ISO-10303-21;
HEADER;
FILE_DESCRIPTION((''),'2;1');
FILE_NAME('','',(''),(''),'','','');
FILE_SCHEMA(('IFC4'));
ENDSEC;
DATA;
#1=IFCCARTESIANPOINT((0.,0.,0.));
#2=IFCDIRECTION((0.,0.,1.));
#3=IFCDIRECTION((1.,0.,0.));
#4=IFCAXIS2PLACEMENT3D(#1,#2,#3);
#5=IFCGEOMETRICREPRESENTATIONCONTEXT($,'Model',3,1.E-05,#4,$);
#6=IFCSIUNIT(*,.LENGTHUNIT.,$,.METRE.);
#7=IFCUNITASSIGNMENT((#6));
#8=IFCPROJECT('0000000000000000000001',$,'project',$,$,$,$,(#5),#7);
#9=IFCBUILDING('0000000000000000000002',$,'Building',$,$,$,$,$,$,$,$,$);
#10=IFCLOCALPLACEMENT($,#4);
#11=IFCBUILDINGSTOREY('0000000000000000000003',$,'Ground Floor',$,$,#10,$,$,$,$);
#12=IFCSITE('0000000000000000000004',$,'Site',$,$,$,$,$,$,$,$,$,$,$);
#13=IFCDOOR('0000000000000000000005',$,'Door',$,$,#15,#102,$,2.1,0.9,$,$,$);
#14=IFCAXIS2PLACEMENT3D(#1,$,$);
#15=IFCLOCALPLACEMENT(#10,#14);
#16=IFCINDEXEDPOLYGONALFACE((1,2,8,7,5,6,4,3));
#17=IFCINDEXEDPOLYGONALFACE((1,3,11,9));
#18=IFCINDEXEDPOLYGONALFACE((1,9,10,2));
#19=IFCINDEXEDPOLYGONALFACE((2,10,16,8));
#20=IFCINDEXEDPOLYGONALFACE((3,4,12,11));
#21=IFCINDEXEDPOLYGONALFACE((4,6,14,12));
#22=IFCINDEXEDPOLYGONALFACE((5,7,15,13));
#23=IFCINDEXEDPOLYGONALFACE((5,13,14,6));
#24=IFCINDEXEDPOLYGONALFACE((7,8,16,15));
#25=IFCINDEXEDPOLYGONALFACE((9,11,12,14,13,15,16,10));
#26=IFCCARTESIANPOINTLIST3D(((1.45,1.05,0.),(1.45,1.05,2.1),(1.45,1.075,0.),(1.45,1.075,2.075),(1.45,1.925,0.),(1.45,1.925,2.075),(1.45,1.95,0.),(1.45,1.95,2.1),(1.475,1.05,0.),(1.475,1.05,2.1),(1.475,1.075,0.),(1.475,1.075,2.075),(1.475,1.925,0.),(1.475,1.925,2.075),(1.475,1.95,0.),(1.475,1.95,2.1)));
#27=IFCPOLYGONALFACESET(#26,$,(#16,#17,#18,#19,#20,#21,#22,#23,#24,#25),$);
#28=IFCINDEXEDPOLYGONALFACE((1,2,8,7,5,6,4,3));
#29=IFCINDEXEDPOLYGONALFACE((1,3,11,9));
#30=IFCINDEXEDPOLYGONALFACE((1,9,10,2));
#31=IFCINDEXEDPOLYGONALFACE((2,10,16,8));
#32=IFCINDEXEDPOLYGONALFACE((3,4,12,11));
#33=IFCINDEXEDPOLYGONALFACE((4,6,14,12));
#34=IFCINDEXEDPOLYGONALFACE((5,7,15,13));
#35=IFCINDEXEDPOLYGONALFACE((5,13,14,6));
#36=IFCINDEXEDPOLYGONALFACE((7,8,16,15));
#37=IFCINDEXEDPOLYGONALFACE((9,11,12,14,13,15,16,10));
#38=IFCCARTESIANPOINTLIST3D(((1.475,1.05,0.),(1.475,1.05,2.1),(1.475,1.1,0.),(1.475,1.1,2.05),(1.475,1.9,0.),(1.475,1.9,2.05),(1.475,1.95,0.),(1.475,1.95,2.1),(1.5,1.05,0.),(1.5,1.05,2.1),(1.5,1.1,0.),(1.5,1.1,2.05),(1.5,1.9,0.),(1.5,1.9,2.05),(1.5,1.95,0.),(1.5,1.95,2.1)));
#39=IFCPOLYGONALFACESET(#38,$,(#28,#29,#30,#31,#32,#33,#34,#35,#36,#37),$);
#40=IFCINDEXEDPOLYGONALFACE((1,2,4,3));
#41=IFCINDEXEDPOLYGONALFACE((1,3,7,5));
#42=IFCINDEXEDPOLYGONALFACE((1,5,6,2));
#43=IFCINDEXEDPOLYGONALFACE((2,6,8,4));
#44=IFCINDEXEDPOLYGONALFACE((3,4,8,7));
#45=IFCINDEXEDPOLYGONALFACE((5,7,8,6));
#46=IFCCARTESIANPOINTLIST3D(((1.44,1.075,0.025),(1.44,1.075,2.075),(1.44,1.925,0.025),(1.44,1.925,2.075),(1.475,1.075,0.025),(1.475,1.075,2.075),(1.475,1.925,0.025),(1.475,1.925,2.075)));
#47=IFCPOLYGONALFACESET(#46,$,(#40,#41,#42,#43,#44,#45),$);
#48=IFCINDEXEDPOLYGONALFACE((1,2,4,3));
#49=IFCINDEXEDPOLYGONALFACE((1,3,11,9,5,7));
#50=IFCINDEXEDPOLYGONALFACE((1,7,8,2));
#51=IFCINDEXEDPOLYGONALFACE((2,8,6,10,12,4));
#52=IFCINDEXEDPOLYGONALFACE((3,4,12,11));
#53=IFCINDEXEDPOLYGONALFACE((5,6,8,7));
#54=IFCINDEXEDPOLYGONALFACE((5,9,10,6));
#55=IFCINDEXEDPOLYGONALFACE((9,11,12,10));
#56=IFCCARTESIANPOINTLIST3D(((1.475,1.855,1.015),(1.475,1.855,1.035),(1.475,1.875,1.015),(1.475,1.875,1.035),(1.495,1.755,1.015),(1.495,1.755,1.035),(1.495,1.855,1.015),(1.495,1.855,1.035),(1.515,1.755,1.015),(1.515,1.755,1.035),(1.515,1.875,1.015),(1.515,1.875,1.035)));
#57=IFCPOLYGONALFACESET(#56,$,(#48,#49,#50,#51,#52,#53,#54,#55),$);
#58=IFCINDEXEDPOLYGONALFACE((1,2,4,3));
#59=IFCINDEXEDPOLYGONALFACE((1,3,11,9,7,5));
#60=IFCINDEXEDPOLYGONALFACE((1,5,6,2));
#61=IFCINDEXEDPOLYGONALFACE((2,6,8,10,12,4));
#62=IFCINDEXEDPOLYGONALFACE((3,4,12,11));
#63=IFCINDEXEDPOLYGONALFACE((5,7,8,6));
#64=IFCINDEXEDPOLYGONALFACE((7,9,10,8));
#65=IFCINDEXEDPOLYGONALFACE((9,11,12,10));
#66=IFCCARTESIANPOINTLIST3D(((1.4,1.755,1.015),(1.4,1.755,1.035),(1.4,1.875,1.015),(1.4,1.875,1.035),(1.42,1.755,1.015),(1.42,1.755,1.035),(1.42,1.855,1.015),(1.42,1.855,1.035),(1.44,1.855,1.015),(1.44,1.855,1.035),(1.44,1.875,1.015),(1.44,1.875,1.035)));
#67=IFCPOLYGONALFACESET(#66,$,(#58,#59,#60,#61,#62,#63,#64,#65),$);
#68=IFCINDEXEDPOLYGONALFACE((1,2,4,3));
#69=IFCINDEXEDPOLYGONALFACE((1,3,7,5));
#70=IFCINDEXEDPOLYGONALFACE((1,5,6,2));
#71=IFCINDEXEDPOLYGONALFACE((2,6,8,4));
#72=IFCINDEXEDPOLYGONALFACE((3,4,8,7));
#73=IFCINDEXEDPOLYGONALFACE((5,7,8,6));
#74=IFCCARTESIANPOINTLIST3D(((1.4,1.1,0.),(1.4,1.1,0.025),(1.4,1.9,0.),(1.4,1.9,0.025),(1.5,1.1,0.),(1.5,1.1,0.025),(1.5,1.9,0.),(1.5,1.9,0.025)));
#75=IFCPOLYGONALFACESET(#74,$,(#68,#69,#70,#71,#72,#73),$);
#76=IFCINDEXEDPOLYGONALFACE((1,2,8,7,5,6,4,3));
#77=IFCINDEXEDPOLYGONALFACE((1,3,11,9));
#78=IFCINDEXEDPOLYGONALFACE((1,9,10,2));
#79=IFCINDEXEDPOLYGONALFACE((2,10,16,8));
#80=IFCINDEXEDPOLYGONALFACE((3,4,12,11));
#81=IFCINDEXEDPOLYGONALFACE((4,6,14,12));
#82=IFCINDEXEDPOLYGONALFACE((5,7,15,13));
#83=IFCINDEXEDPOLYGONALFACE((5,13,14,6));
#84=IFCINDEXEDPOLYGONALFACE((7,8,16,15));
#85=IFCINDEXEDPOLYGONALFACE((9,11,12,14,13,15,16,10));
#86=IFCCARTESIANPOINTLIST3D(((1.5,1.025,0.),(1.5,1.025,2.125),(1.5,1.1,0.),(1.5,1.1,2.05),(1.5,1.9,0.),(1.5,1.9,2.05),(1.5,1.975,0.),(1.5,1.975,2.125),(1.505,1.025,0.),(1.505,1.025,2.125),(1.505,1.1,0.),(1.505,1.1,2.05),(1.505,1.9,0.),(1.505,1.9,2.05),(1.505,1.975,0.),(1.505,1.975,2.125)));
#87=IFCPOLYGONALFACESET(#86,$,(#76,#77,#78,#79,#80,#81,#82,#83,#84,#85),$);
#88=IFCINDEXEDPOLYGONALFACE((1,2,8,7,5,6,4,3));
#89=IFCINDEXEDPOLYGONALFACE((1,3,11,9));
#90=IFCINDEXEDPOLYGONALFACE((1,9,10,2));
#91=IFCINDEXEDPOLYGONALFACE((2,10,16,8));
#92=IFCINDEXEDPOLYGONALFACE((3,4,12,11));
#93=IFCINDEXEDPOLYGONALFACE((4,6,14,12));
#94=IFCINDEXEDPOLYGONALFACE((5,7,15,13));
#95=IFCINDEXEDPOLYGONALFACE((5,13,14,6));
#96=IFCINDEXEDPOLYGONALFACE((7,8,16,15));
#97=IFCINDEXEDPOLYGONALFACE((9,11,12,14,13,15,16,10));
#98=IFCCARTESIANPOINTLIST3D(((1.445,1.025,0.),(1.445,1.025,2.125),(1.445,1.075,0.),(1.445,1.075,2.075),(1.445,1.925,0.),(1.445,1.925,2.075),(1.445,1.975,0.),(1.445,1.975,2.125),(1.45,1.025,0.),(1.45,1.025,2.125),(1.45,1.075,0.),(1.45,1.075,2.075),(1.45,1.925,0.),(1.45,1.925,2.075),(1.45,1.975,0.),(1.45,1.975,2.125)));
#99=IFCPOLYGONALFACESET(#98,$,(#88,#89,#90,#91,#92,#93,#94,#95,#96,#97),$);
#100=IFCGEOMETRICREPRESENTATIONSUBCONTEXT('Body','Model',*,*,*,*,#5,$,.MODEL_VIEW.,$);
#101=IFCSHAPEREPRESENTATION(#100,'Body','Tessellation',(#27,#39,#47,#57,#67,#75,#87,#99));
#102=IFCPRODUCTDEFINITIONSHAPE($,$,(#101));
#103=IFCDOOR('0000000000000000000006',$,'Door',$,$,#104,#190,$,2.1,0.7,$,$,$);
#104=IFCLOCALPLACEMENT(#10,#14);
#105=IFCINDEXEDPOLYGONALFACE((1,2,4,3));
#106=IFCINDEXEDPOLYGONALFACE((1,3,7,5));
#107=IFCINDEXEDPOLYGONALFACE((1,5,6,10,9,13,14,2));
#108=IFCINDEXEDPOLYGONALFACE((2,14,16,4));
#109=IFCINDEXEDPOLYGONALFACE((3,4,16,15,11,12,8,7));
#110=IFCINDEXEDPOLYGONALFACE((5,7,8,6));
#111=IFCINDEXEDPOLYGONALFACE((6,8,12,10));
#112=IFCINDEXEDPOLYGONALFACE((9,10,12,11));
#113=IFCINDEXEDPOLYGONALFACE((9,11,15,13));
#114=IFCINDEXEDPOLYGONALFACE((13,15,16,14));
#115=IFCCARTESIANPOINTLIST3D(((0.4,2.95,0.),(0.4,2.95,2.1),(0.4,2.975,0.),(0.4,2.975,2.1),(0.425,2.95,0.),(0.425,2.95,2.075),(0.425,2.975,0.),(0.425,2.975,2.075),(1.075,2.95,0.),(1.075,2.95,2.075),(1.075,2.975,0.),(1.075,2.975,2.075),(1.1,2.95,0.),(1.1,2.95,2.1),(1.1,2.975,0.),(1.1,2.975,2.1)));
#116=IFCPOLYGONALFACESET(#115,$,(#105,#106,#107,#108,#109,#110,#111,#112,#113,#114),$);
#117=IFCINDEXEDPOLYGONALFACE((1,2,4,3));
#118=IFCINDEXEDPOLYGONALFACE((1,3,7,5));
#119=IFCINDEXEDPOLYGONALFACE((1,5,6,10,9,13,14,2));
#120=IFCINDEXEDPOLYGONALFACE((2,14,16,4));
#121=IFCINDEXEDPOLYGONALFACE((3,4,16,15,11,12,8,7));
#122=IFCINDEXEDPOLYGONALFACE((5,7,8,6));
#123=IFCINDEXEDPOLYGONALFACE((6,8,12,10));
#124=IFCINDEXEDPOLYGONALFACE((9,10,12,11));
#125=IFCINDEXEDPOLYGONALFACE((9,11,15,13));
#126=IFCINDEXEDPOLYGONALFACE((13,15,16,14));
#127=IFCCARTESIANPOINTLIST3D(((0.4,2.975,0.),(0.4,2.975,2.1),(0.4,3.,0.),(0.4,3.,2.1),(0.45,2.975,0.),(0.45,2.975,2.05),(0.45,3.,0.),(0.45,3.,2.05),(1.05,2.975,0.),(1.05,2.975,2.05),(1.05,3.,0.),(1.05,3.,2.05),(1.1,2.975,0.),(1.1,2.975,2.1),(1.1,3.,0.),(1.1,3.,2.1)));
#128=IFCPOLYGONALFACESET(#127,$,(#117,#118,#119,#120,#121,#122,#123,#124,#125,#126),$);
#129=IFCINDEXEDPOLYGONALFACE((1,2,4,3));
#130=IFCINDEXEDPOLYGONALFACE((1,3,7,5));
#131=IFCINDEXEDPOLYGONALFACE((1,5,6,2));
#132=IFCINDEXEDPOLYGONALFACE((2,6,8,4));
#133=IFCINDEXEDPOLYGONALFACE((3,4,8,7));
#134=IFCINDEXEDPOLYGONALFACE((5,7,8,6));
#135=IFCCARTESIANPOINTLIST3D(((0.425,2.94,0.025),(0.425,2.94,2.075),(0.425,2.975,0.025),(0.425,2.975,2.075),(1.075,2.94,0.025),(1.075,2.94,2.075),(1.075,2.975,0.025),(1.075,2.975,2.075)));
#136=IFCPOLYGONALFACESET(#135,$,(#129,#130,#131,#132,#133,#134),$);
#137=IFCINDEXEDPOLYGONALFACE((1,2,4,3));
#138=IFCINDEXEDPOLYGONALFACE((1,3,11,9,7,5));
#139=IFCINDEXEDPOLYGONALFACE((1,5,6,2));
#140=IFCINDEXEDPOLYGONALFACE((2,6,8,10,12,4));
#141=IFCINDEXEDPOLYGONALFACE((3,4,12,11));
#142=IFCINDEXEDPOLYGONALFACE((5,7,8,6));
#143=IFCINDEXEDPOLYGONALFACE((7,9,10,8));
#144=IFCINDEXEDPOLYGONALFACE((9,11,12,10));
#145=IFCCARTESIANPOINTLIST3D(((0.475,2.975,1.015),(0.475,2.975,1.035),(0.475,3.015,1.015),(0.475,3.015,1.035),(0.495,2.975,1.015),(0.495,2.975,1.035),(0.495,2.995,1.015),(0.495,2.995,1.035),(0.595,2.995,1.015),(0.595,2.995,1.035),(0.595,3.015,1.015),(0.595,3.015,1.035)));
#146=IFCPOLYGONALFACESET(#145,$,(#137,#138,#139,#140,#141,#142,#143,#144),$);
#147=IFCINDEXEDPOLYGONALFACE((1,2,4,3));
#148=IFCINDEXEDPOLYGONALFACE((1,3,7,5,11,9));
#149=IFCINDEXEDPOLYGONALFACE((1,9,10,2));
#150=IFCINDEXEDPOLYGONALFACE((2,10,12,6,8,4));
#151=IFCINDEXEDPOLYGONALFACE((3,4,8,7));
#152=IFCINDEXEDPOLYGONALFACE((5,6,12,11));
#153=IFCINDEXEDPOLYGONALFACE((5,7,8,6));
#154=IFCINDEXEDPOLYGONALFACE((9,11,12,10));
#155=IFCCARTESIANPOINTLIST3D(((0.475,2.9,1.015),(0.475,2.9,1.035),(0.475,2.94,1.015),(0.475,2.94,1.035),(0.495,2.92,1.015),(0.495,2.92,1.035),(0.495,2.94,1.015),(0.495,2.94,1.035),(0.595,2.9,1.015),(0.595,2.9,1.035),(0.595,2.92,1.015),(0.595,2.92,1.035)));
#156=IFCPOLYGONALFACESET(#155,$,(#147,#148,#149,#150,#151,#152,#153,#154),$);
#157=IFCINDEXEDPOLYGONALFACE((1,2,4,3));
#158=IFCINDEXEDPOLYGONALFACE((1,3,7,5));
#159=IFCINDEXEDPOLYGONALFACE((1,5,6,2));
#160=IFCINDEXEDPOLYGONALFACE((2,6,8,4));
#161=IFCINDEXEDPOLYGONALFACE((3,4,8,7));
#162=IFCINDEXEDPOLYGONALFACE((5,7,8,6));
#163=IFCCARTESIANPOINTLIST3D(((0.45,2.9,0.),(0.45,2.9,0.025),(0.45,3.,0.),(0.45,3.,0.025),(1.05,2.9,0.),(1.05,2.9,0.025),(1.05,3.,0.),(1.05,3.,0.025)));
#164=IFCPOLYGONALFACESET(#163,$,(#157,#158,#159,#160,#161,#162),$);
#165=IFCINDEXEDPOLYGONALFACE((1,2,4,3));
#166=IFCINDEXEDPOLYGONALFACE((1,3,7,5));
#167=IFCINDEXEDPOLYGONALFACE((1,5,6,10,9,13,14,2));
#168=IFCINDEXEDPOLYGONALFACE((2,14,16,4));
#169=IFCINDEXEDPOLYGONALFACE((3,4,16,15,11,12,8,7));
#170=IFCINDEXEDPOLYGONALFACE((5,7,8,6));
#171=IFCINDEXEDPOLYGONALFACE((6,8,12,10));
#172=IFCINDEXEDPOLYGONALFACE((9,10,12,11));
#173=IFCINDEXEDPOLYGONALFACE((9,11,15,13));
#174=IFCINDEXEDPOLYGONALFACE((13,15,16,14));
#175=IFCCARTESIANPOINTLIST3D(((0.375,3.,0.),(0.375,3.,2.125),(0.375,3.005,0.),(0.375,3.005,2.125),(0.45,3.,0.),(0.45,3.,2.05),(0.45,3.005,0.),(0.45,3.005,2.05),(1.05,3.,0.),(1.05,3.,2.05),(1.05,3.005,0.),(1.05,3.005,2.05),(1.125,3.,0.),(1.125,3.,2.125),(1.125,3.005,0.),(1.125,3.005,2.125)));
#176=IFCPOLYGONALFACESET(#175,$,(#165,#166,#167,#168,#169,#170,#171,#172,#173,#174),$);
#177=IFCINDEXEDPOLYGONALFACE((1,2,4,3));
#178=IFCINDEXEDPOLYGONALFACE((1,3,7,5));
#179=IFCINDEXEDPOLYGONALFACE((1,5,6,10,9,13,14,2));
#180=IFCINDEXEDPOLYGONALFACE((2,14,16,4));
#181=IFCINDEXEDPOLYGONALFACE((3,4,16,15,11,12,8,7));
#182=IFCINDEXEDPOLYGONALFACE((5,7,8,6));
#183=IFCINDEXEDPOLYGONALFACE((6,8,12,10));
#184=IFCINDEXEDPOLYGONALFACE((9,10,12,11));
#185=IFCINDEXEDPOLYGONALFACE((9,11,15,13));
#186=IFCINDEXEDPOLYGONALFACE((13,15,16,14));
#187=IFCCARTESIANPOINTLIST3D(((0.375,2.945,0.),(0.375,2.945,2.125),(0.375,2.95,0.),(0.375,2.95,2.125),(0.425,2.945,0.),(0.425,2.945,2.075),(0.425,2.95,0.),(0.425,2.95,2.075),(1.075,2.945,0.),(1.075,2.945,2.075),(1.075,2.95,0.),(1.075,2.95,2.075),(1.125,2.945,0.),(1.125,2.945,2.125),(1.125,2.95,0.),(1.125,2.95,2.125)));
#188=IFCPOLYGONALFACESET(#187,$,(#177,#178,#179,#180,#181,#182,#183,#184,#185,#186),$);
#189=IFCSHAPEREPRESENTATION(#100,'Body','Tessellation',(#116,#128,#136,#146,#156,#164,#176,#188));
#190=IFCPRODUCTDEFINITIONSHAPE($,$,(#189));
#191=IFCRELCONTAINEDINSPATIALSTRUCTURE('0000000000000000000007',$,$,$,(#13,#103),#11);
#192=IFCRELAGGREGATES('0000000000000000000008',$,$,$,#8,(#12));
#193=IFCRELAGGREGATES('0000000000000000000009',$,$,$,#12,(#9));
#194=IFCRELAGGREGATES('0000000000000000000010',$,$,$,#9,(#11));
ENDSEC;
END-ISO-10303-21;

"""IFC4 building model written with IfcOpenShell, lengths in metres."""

from ifc_helpers import new_model, si_unit, frame, origin_with_axes, place, context, subcontext, project, spatial, line, indexed_curve, outline, extrude, element, save


model = new_model("IFC4")

# Units and contexts
model_context = context("Model", 3, precision=1e-05, world=origin_with_axes())
body_context = subcontext(model_context, "Body", "Model", "MODEL_VIEW")
ifc_project = project(units=[si_unit("LENGTHUNIT", "METRE")], contexts=[model_context])

# Site, building, storey
site = spatial("IfcSite", under=ifc_project, Name="Site")
building = spatial("IfcBuilding", under=site, Name="Building")
storey_placement = place(None, origin_with_axes())
storey = spatial("IfcBuildingStorey", under=building, at=storey_placement, Name="Ground Floor")

# Doors
door_1_placement = place(storey_placement, frame((1.5, 1.05, 0.0), z_axis=(0.0, 0.0, 1.0), x_axis=(0.0, 1.0, 0.0)))
element("IfcDoor", 1, at=door_1_placement, inside=storey, Name="Door", OverallHeight=2.1, OverallWidth=0.9, context=body_context, shape_type="SweptSolid", body=[
    extrude(outline(indexed_curve([(0.0, 0.0), (0.0, 2.1), (0.9, 2.1), (0.9, 0.0), (0.875, 0.0), (0.875, 2.075), (0.025, 2.075), (0.025, 0.0)], segments=[line(1, 2, 3, 4, 5, 6, 7, 8, 1)])), frame((0.0, 0.025, 0.0), z_axis=(0.0, -1.0, 0.0), x_axis=(1.0, 0.0, 0.0)), (0.0, 0.0, -1.0), 0.025),
    extrude(outline(indexed_curve([(0.0, 0.0), (0.0, 2.1), (0.9, 2.1), (0.9, 0.0), (0.85, 0.0), (0.85, 2.05), (0.05, 2.05), (0.05, 0.0)], segments=[line(1, 2, 3, 4, 5, 6, 7, 8, 1)])), frame((0.0, 0.0, 0.0), z_axis=(0.0, -1.0, 0.0), x_axis=(1.0, 0.0, 0.0)), (0.0, 0.0, -1.0), 0.025),
    extrude(outline(indexed_curve([(0.0, 0.0), (0.85, 0.0), (0.85, 0.035), (0.0, 0.035)], segments=[line(1, 2, 3, 4, 1)])), frame((0.025, 0.025, 0.025), z_axis=(0.0, 0.0, 1.0), x_axis=(1.0, 0.0, 0.0)), (0.0, 0.0, 1.0), 2.05),
    extrude(outline(indexed_curve([(0.0, 0.0), (0.0, -0.04), (-0.12, -0.04), (-0.12, -0.02), (-0.02, -0.02), (-0.02, 0.0)], segments=[line(1, 2, 3, 4, 5, 6, 1)])), frame((0.825, 0.025, 1.015), z_axis=(0.0, 0.0, 1.0), x_axis=(1.0, 0.0, 0.0)), (0.0, 0.0, 1.0), 0.02),
    extrude(outline(indexed_curve([(0.0, 0.0), (0.0, 0.04), (-0.12, 0.04), (-0.12, 0.02), (-0.02, 0.02), (-0.02, 0.0)], segments=[line(1, 2, 3, 4, 5, 6, 1)])), frame((0.825, 0.06, 1.015), z_axis=(0.0, 0.0, 1.0), x_axis=(1.0, 0.0, 0.0)), (0.0, 0.0, 1.0), 0.02),
    extrude(outline(indexed_curve([(0.0, 0.0), (0.8, 0.0), (0.8, 0.1), (0.0, 0.1)], segments=[line(1, 2, 3, 4, 1)])), frame((0.05, 0.0, 0.0), z_axis=(0.0, 0.0, 1.0), x_axis=(1.0, 0.0, 0.0)), (0.0, 0.0, 1.0), 0.025),
    extrude(outline(indexed_curve([(0.0, 0.0), (0.0, 2.125), (0.95, 2.125), (0.95, 0.0), (0.875, 0.0), (0.875, 2.05), (0.075, 2.05), (0.075, 0.0)], segments=[line(1, 2, 3, 4, 5, 6, 7, 8, 1)])), frame((-0.025, -0.005, 0.0), z_axis=(0.0, -1.0, 0.0), x_axis=(1.0, 0.0, 0.0)), (0.0, 0.0, -1.0), 0.005),
    extrude(outline(indexed_curve([(0.0, 0.0), (0.0, 2.125), (0.95, 2.125), (0.95, 0.0), (0.9, 0.0), (0.9, 2.075), (0.05, 2.075), (0.05, 0.0)], segments=[line(1, 2, 3, 4, 5, 6, 7, 8, 1)])), frame((-0.025, 0.05, 0.0), z_axis=(0.0, -1.0, 0.0), x_axis=(1.0, 0.0, 0.0)), (0.0, 0.0, -1.0), 0.005),
])
door_2_placement = place(storey_placement, frame((1.1, 3.0, 0.0), z_axis=(0.0, 0.0, 1.0), x_axis=(-1.0, 0.0, 0.0)))
element("IfcDoor", 2, at=door_2_placement, inside=storey, Name="Door", OverallHeight=2.1, OverallWidth=0.7, context=body_context, shape_type="SweptSolid", body=[
    extrude(outline(indexed_curve([(0.0, 0.0), (0.0, 2.1), (0.7, 2.1), (0.7, 0.0), (0.675, 0.0), (0.675, 2.075), (0.025, 2.075), (0.025, 0.0)], segments=[line(1, 2, 3, 4, 5, 6, 7, 8, 1)])), frame((0.0, 0.025, 0.0), z_axis=(0.0, -1.0, 0.0), x_axis=(1.0, 0.0, 0.0)), (0.0, 0.0, -1.0), 0.025),
    extrude(outline(indexed_curve([(0.0, 0.0), (0.0, 2.1), (0.7, 2.1), (0.7, 0.0), (0.65, 0.0), (0.65, 2.05), (0.05, 2.05), (0.05, 0.0)], segments=[line(1, 2, 3, 4, 5, 6, 7, 8, 1)])), frame((0.0, 0.0, 0.0), z_axis=(0.0, -1.0, 0.0), x_axis=(1.0, 0.0, 0.0)), (0.0, 0.0, -1.0), 0.025),
    extrude(outline(indexed_curve([(0.0, 0.0), (0.65, 0.0), (0.65, 0.035), (0.0, 0.035)], segments=[line(1, 2, 3, 4, 1)])), frame((0.025, 0.025, 0.025), z_axis=(0.0, 0.0, 1.0), x_axis=(1.0, 0.0, 0.0)), (0.0, 0.0, 1.0), 2.05),
    extrude(outline(indexed_curve([(0.0, 0.0), (0.0, -0.04), (-0.12, -0.04), (-0.12, -0.02), (-0.02, -0.02), (-0.02, 0.0)], segments=[line(1, 2, 3, 4, 5, 6, 1)])), frame((0.625, 0.025, 1.015), z_axis=(0.0, 0.0, 1.0), x_axis=(1.0, 0.0, 0.0)), (0.0, 0.0, 1.0), 0.02),
    extrude(outline(indexed_curve([(0.0, 0.0), (0.0, 0.04), (-0.12, 0.04), (-0.12, 0.02), (-0.02, 0.02), (-0.02, 0.0)], segments=[line(1, 2, 3, 4, 5, 6, 1)])), frame((0.625, 0.06, 1.015), z_axis=(0.0, 0.0, 1.0), x_axis=(1.0, 0.0, 0.0)), (0.0, 0.0, 1.0), 0.02),
    extrude(outline(indexed_curve([(0.0, 0.0), (0.6, 0.0), (0.6, 0.1), (0.0, 0.1)], segments=[line(1, 2, 3, 4, 1)])), frame((0.05, 0.0, 0.0), z_axis=(0.0, 0.0, 1.0), x_axis=(1.0, 0.0, 0.0)), (0.0, 0.0, 1.0), 0.025),
    extrude(outline(indexed_curve([(0.0, 0.0), (0.0, 2.125), (0.75, 2.125), (0.75, 0.0), (0.675, 0.0), (0.675, 2.05), (0.075, 2.05), (0.075, 0.0)], segments=[line(1, 2, 3, 4, 5, 6, 7, 8, 1)])), frame((-0.025, -0.005, 0.0), z_axis=(0.0, -1.0, 0.0), x_axis=(1.0, 0.0, 0.0)), (0.0, 0.0, -1.0), 0.005),
    extrude(outline(indexed_curve([(0.0, 0.0), (0.0, 2.125), (0.75, 2.125), (0.75, 0.0), (0.7, 0.0), (0.7, 2.075), (0.05, 2.075), (0.05, 0.0)], segments=[line(1, 2, 3, 4, 5, 6, 7, 8, 1)])), frame((-0.025, 0.05, 0.0), z_axis=(0.0, -1.0, 0.0), x_axis=(1.0, 0.0, 0.0)), (0.0, 0.0, -1.0), 0.005),
])

save(model, "model.ifc")
